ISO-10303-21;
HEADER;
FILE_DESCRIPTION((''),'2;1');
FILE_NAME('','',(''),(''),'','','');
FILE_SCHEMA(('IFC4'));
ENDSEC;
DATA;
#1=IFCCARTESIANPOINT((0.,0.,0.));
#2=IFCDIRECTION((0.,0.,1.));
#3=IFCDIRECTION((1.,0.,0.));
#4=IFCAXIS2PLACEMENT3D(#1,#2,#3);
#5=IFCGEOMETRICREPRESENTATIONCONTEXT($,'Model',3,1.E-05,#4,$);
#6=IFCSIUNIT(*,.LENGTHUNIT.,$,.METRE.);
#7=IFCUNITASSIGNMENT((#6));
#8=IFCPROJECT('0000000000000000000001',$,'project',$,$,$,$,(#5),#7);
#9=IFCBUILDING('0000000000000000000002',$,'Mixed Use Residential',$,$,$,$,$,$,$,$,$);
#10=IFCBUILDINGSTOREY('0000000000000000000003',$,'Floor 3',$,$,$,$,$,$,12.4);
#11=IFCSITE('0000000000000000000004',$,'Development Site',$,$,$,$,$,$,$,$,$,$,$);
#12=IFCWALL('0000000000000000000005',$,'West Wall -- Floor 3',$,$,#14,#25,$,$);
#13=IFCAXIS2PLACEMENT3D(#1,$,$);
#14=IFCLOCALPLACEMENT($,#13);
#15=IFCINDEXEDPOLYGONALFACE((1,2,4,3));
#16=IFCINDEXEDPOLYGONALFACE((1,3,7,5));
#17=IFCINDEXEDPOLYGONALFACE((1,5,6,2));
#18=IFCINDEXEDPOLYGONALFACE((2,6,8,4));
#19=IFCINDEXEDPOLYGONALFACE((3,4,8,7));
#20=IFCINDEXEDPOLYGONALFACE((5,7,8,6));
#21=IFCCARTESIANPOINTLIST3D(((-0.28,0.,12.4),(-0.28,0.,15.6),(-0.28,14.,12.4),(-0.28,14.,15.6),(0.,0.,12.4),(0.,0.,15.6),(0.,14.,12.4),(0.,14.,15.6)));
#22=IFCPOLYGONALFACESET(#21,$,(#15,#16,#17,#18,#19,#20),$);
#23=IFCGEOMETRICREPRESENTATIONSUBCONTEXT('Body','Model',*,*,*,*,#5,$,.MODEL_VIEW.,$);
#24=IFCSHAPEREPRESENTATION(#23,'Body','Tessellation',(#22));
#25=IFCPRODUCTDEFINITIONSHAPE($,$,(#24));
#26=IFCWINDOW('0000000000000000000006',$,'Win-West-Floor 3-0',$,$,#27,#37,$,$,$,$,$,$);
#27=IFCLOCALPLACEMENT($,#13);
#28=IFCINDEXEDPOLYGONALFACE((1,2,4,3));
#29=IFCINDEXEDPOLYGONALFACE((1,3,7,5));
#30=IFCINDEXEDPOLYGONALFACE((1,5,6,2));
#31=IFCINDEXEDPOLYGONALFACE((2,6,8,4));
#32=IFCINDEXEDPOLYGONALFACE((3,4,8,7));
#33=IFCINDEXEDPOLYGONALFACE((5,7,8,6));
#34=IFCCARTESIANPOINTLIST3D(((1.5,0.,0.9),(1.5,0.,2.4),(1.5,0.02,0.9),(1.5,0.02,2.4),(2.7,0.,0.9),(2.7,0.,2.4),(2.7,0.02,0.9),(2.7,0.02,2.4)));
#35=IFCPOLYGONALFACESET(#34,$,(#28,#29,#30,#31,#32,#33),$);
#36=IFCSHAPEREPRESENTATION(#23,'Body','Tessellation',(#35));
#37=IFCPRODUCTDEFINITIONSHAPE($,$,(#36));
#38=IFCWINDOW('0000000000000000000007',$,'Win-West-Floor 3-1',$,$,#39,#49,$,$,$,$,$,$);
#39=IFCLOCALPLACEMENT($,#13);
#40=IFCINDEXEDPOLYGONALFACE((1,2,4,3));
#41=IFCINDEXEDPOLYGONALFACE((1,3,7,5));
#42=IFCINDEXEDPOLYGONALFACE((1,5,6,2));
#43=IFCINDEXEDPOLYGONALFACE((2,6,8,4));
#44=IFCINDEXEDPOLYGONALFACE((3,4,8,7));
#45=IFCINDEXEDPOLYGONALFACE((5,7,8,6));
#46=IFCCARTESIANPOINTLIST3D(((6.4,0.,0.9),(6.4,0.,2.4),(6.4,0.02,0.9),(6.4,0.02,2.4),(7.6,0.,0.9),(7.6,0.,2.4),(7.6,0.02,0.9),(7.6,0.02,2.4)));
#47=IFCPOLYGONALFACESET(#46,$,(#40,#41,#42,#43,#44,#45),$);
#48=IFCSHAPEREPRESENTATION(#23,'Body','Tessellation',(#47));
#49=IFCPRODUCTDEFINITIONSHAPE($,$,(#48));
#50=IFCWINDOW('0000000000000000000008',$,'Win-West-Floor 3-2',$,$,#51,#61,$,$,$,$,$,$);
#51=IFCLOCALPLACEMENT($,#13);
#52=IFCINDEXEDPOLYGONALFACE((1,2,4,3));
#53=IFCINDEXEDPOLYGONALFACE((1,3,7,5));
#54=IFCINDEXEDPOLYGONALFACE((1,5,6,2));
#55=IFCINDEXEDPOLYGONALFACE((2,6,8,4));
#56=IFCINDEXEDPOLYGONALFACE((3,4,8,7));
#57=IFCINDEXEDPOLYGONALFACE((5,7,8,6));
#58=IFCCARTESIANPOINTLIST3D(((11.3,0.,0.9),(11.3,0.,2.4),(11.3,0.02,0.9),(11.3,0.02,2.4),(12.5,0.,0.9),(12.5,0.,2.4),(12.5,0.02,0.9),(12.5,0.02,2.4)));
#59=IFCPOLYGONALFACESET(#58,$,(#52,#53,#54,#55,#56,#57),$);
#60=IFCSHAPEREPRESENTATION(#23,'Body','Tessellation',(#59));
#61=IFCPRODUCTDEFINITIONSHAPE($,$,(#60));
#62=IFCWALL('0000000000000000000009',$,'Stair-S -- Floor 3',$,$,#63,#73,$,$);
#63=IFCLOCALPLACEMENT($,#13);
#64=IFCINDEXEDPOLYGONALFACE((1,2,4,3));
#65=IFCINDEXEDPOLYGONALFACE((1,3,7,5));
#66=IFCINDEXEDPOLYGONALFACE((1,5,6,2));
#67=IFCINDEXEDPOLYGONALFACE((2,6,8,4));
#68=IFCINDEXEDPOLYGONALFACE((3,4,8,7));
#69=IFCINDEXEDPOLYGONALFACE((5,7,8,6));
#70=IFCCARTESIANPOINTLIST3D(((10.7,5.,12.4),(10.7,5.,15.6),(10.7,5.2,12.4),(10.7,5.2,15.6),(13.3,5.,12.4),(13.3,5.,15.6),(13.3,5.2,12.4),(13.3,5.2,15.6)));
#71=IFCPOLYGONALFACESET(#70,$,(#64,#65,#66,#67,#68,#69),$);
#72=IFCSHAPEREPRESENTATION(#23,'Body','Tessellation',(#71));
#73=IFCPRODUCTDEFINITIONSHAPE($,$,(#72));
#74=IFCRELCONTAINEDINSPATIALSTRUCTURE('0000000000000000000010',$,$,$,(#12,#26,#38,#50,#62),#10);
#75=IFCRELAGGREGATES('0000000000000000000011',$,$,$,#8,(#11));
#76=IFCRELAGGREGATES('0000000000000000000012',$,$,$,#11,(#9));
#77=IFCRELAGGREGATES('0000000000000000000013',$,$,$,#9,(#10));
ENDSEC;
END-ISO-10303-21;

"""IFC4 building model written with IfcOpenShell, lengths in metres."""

from ifc_helpers import new_model, si_unit, frame, origin_with_axes, place, context, subcontext, project, spatial, indexed_curve, outline, extrude, element, fill, save


model = new_model("IFC4")

# Units and contexts
model_context = context("Model", 3, precision=1e-05, world=origin_with_axes())
body_context = subcontext(model_context, "Body", "Model", "MODEL_VIEW")
ifc_project = project(units=[si_unit("LENGTHUNIT", "METRE")], contexts=[model_context])

# Site, building, storey
site = spatial("IfcSite", under=ifc_project, Name="Development Site")
building = spatial("IfcBuilding", under=site, Name="Mixed Use Residential")
storey = spatial("IfcBuildingStorey", under=building, Name="Floor 3", Elevation=12.4)

# Wall, openings, windows
wall_1_placement = place(None, frame((0.0, 0.0, 12.4), z_axis=(0.0, 0.0, 1.0), x_axis=(0.0, 1.0, 0.0)))
wall_1 = element("IfcWall", 1, at=wall_1_placement, inside=storey, Name="West Wall -- Floor 3", context=body_context, shape_type="SweptSolid", body=[
    extrude(outline(indexed_curve([(0.0, 0.0), (0.0, 0.28), (14.0, 0.28), (14.0, 0.0), (0.0, 0.0)], self_intersect=False)), origin_with_axes(), (0.0, 0.0, 1.0), 3.2),
])
opening_1_placement = place(wall_1_placement, frame((0.0, -1.5, -11.5), z_axis=(0.0, 0.0, 1.0), x_axis=(0.0, -1.0, 0.0)))
opening_1 = element("IfcOpeningElement", 2, at=opening_1_placement, cuts=wall_1, context=body_context, shape_type="SweptSolid", body=[
    extrude(outline(indexed_curve([(0.0, 0.0), (0.0, 0.28), (1.2, 0.28), (1.2, 0.0), (0.0, 0.0)], self_intersect=False)), origin_with_axes(), (0.0, 0.0, 1.0), 1.5),
])
opening_2_placement = place(wall_1_placement, frame((0.0, -6.4, -11.5), z_axis=(0.0, 0.0, 1.0), x_axis=(0.0, -1.0, 0.0)))
opening_2 = element("IfcOpeningElement", 3, at=opening_2_placement, cuts=wall_1, context=body_context, shape_type="SweptSolid", body=[
    extrude(outline(indexed_curve([(0.0, 0.0), (0.0, 0.28), (1.2, 0.28), (1.2, 0.0), (0.0, 0.0)], self_intersect=False)), origin_with_axes(), (0.0, 0.0, 1.0), 1.5),
])
opening_3_placement = place(wall_1_placement, frame((0.0, -11.3, -11.5), z_axis=(0.0, 0.0, 1.0), x_axis=(0.0, -1.0, 0.0)))
opening_3 = element("IfcOpeningElement", 4, at=opening_3_placement, cuts=wall_1, context=body_context, shape_type="SweptSolid", body=[
    extrude(outline(indexed_curve([(0.0, 0.0), (0.0, 0.28), (1.2, 0.28), (1.2, 0.0), (0.0, 0.0)], self_intersect=False)), origin_with_axes(), (0.0, 0.0, 1.0), 1.5),
])
window_1_placement = place(None, frame((1.5, 0.0, 0.9), z_axis=(0.0, 0.0, 1.0), x_axis=(1.0, 0.0, 0.0)))
window_1 = element("IfcWindow", 5, at=window_1_placement, inside=storey, Name="Win-West-Floor 3-0", context=body_context, shape_type="SweptSolid", body=[
    extrude(outline(indexed_curve([(0.0, 0.0), (0.0, 0.02), (1.2, 0.02), (1.2, 0.0), (0.0, 0.0)], self_intersect=False)), origin_with_axes(), (0.0, 0.0, 1.0), 1.5),
])
fill(opening_1, window_1)
window_2_placement = place(None, frame((6.4, 0.0, 0.9), z_axis=(0.0, 0.0, 1.0), x_axis=(1.0, 0.0, 0.0)))
window_2 = element("IfcWindow", 6, at=window_2_placement, inside=storey, Name="Win-West-Floor 3-1", context=body_context, shape_type="SweptSolid", body=[
    extrude(outline(indexed_curve([(0.0, 0.0), (0.0, 0.02), (1.2, 0.02), (1.2, 0.0), (0.0, 0.0)], self_intersect=False)), origin_with_axes(), (0.0, 0.0, 1.0), 1.5),
])
fill(opening_2, window_2)
window_3_placement = place(None, frame((11.3, 0.0, 0.9), z_axis=(0.0, 0.0, 1.0), x_axis=(1.0, 0.0, 0.0)))
window_3 = element("IfcWindow", 7, at=window_3_placement, inside=storey, Name="Win-West-Floor 3-2", context=body_context, shape_type="SweptSolid", body=[
    extrude(outline(indexed_curve([(0.0, 0.0), (0.0, 0.02), (1.2, 0.02), (1.2, 0.0), (0.0, 0.0)], self_intersect=False)), origin_with_axes(), (0.0, 0.0, 1.0), 1.5),
])
fill(opening_3, window_3)

# Wall
wall_2_placement = place(None, frame((10.7, 5.0, 12.4), z_axis=(0.0, 0.0, 1.0), x_axis=(1.0, 0.0, 0.0)))
element("IfcWall", 8, at=wall_2_placement, inside=storey, Name="Stair-S -- Floor 3", context=body_context, shape_type="SweptSolid", body=[
    extrude(outline(indexed_curve([(0.0, 0.0), (0.0, 0.2), (2.6, 0.2), (2.6, 0.0), (0.0, 0.0)], self_intersect=False)), origin_with_axes(), (0.0, 0.0, 1.0), 3.2),
])

save(model, "model.ifc")
